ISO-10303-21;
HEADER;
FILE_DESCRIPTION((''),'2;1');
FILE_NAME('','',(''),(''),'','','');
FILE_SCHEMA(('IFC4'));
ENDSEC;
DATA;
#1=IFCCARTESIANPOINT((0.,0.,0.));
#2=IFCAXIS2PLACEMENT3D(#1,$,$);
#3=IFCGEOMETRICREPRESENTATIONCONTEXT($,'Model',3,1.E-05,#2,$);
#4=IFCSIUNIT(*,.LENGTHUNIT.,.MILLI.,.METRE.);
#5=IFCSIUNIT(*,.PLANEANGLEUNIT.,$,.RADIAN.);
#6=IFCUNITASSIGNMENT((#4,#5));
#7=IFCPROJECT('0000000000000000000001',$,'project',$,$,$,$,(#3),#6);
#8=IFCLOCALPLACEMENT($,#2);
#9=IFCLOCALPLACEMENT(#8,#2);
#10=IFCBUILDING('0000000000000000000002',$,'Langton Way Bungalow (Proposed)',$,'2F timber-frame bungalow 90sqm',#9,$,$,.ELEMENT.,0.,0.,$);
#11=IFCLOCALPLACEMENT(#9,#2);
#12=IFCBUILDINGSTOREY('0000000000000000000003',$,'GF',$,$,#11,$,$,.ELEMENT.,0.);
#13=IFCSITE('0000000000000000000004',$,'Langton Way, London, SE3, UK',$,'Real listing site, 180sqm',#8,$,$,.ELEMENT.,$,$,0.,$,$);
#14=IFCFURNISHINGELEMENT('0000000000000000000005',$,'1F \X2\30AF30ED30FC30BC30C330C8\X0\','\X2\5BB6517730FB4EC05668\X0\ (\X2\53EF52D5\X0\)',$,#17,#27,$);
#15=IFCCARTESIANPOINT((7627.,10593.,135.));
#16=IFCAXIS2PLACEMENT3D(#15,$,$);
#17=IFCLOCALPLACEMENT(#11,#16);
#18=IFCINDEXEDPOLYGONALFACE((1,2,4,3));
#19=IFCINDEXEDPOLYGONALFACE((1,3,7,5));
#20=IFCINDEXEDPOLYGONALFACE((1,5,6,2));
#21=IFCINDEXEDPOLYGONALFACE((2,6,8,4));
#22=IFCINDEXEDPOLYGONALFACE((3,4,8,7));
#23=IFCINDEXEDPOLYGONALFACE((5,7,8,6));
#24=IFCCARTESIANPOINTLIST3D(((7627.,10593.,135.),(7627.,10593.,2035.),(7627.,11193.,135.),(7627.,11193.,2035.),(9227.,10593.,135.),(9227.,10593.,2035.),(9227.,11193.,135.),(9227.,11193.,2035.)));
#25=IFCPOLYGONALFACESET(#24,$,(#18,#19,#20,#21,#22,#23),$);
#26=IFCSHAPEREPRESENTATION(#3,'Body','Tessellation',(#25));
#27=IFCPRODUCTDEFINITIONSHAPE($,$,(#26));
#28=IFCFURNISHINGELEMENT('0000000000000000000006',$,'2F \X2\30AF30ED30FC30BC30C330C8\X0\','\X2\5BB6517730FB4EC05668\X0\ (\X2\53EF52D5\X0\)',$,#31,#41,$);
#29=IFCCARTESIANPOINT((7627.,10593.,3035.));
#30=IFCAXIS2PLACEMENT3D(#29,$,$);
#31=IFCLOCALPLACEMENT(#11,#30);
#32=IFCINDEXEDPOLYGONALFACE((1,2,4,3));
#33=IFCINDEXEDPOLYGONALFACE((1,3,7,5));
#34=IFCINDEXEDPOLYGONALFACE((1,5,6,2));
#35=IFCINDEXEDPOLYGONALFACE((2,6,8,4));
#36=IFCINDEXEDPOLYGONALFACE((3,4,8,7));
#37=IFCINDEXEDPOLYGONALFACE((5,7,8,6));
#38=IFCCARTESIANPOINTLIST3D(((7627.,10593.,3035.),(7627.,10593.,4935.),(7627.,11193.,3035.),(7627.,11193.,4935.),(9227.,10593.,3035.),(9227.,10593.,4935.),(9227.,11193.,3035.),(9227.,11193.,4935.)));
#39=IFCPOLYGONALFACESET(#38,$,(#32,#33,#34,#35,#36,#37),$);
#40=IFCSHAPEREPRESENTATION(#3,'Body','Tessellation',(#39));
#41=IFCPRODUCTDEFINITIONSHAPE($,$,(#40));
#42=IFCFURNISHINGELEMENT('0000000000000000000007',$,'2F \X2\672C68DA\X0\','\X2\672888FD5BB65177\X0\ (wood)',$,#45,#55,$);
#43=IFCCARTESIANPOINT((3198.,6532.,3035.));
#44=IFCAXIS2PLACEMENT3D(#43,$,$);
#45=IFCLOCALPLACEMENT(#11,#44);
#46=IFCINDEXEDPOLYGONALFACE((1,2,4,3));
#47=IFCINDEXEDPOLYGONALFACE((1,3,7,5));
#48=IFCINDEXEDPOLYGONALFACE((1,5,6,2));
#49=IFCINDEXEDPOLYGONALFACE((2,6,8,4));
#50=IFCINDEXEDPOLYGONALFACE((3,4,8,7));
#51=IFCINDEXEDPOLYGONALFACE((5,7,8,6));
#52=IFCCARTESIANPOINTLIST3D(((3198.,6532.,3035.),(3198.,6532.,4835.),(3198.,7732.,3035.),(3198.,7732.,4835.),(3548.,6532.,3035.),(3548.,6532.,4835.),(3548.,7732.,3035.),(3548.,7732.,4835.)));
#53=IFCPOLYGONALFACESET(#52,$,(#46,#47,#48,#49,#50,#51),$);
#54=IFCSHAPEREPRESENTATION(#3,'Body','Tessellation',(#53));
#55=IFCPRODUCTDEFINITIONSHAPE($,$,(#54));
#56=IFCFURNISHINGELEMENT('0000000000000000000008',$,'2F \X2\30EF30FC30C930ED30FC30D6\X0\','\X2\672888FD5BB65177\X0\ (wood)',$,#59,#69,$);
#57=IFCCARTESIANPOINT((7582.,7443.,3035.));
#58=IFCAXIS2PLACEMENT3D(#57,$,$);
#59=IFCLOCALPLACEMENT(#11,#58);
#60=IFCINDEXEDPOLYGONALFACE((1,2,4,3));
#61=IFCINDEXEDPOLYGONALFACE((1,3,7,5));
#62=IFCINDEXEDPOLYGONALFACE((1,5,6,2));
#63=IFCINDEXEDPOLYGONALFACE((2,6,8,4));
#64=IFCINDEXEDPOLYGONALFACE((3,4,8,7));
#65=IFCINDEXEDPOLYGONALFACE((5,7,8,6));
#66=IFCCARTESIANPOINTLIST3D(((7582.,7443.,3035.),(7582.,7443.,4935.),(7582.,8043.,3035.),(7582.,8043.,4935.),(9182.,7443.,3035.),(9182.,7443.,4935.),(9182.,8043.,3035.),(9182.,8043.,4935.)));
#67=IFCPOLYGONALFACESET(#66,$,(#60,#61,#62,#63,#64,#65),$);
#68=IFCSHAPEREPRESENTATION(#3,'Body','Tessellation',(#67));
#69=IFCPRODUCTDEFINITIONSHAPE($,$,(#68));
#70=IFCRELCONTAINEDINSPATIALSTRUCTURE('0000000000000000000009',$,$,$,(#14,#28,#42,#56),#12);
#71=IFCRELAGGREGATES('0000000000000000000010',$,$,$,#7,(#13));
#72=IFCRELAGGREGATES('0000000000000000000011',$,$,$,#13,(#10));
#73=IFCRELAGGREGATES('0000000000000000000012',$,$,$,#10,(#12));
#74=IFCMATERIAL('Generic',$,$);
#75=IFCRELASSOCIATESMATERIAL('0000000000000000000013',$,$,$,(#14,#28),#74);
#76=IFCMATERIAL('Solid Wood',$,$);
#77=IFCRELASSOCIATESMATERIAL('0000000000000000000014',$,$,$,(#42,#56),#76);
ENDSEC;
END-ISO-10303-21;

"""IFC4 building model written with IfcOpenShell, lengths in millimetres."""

from ifc_helpers import new_model, si_unit, frame, frame_2d, origin, place, context, project, spatial, rectangle, extrude, material, element, save


model = new_model("IFC4")

# Units and contexts
model_context = context("Model", 3, precision=1e-05, world=origin())
ifc_project = project(units=[si_unit("LENGTHUNIT", "METRE", prefix="MILLI"), si_unit("PLANEANGLEUNIT", "RADIAN")], contexts=[model_context])

# Site, building, storey
site_placement = place(None, origin())
site = spatial("IfcSite", under=ifc_project, at=site_placement, Name="Langton Way, London, SE3, UK", ObjectType="Real listing site, 180sqm", CompositionType="ELEMENT", RefElevation=0.0)
building_placement = place(site_placement, origin())
building = spatial("IfcBuilding", under=site, at=building_placement, Name="Langton Way Bungalow (Proposed)", ObjectType="2F timber-frame bungalow 90sqm", CompositionType="ELEMENT", ElevationOfRefHeight=0.0, ElevationOfTerrain=0.0)
storey_placement = place(building_placement, origin())
storey = spatial("IfcBuildingStorey", under=building, at=storey_placement, Name="GF", CompositionType="ELEMENT", Elevation=0.0)

# Shared definitions
ifc_material_1 = material(Name="Solid Wood")

# Shared definitions
ifc_material_2 = material(Name="Generic")

# Furnishing elements
furnishing_1_placement = place(storey_placement, frame((7627.0, 10593.0, 135.0)))
element("IfcFurnishingElement", 1, at=furnishing_1_placement, inside=storey, material=ifc_material_2, Name="1F クローゼット", Description="家具・什器 (可動)", context=model_context, shape_type="SweptSolid", body=[
    extrude(rectangle(XDim=1600.0, YDim=600.0, at=frame_2d((800.0, 300.0))), frame((7627.0, 10593.0, 135.0)), (0.0, 0.0, 1.0), 1900.0),
])
furnishing_2_placement = place(storey_placement, frame((7627.0, 10593.0, 3035.0)))
element("IfcFurnishingElement", 2, at=furnishing_2_placement, inside=storey, material=ifc_material_2, Name="2F クローゼット", Description="家具・什器 (可動)", context=model_context, shape_type="SweptSolid", body=[
    extrude(rectangle(XDim=1600.0, YDim=600.0, at=frame_2d((800.0, 300.0))), frame((7627.0, 10593.0, 3035.0)), (0.0, 0.0, 1.0), 1900.0),
])
furnishing_3_placement = place(storey_placement, frame((3198.0, 6532.0, 3035.0)))
element("IfcFurnishingElement", 3, at=furnishing_3_placement, inside=storey, material=ifc_material_1, Name="2F 本棚", Description="木製家具 (wood)", context=model_context, shape_type="SweptSolid", body=[
    extrude(rectangle(XDim=350.0, YDim=1200.0, at=frame_2d((175.0, 600.0))), frame((3198.0, 6532.0, 3035.0)), (0.0, 0.0, 1.0), 1800.0),
])
furnishing_4_placement = place(storey_placement, frame((7582.0, 7443.0, 3035.0)))
element("IfcFurnishingElement", 4, at=furnishing_4_placement, inside=storey, material=ifc_material_1, Name="2F ワードローブ", Description="木製家具 (wood)", context=model_context, shape_type="SweptSolid", body=[
    extrude(rectangle(XDim=1600.0, YDim=600.0, at=frame_2d((800.0, 300.0))), frame((7582.0, 7443.0, 3035.0)), (0.0, 0.0, 1.0), 1900.0),
])

save(model, "model.ifc")
